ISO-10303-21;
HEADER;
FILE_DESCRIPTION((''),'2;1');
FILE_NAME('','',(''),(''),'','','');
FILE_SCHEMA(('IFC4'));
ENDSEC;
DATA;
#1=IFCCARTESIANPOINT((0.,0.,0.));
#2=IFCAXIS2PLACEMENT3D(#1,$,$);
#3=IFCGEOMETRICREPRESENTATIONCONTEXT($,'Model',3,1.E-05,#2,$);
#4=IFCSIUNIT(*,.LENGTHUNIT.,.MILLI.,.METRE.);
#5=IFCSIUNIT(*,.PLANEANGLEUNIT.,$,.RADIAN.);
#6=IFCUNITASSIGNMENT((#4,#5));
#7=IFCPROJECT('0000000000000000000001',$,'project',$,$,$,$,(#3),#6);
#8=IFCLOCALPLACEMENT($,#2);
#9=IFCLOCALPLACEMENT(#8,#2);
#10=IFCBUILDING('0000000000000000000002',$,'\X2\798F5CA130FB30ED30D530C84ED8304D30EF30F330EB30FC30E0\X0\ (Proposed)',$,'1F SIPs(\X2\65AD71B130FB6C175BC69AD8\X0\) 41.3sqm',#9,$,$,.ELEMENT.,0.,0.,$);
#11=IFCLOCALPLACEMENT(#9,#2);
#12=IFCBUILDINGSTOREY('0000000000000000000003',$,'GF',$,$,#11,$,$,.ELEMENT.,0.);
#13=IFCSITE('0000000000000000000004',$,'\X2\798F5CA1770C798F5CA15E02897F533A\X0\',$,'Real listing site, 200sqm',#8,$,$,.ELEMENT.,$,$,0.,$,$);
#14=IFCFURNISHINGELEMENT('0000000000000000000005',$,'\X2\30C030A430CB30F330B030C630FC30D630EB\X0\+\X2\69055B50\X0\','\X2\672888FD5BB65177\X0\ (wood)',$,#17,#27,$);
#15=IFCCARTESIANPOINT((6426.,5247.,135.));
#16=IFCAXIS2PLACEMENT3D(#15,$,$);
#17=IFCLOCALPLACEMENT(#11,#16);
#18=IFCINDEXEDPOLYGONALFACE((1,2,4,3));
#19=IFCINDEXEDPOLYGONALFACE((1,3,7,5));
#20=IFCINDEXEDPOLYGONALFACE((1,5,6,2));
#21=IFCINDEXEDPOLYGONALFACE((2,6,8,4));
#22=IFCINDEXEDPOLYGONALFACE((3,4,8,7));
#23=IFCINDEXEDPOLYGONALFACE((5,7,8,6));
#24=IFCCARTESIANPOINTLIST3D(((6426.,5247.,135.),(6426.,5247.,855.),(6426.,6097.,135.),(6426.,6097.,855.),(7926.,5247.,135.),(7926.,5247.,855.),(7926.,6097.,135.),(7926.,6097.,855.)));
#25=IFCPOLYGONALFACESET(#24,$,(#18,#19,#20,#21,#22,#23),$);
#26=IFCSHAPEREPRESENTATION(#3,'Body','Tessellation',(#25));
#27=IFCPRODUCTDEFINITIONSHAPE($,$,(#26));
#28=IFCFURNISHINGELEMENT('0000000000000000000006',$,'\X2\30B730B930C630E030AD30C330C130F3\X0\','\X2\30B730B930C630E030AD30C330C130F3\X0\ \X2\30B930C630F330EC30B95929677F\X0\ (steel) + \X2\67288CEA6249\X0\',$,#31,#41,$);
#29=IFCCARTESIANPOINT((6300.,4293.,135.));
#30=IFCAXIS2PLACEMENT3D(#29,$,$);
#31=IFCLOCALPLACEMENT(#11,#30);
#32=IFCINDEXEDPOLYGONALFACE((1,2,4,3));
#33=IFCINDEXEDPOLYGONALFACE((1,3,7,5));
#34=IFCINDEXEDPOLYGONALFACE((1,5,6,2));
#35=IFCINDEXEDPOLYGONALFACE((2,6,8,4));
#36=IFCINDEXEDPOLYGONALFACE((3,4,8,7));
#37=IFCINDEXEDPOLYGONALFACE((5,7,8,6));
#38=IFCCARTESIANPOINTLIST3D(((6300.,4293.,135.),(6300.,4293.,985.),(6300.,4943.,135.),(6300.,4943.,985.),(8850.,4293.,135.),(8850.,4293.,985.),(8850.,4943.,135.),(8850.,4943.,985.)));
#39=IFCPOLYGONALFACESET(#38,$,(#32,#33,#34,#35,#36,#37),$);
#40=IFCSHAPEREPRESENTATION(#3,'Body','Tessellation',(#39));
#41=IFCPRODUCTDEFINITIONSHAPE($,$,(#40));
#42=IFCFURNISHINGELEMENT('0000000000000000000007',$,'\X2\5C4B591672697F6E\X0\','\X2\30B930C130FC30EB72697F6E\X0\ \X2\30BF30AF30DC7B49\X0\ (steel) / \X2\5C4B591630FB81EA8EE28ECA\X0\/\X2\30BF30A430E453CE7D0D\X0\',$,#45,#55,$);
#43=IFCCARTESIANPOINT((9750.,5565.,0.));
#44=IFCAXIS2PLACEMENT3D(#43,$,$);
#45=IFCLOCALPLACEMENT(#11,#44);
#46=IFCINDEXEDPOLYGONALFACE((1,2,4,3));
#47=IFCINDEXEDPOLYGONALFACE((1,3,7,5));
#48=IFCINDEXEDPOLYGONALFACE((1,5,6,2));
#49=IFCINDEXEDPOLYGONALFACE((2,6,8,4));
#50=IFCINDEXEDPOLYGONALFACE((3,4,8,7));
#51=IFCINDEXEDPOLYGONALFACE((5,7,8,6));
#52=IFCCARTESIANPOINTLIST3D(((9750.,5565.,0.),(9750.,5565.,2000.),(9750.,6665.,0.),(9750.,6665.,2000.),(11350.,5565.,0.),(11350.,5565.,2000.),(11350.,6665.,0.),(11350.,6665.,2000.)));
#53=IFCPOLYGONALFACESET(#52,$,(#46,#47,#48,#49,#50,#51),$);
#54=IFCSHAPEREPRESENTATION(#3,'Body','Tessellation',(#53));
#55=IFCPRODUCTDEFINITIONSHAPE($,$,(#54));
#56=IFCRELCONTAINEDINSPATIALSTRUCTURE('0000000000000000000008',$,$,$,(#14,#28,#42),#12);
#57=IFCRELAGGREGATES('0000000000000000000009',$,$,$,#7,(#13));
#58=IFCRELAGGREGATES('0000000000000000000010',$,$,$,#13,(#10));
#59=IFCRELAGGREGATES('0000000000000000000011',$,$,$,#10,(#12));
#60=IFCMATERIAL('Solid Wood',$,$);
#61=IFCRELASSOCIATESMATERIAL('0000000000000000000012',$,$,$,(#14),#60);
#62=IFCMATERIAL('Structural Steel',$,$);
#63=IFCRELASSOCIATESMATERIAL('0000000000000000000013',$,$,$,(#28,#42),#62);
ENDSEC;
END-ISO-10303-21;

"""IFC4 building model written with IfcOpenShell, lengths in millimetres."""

from ifc_helpers import new_model, si_unit, frame, frame_2d, origin, place, context, project, spatial, rectangle, extrude, material, element, save


model = new_model("IFC4")

# Units and contexts
model_context = context("Model", 3, precision=1e-05, world=origin())
ifc_project = project(units=[si_unit("LENGTHUNIT", "METRE", prefix="MILLI"), si_unit("PLANEANGLEUNIT", "RADIAN")], contexts=[model_context])

# Site, building, storey
site_placement = place(None, origin())
site = spatial("IfcSite", under=ifc_project, at=site_placement, Name="福岡県福岡市西区", ObjectType="Real listing site, 200sqm", CompositionType="ELEMENT", RefElevation=0.0)
building_placement = place(site_placement, origin())
building = spatial("IfcBuilding", under=site, at=building_placement, Name="福岡・ロフト付きワンルーム (Proposed)", ObjectType="1F SIPs(断熱・気密高) 41.3sqm", CompositionType="ELEMENT", ElevationOfRefHeight=0.0, ElevationOfTerrain=0.0)
storey_placement = place(building_placement, origin())
storey = spatial("IfcBuildingStorey", under=building, at=storey_placement, Name="GF", CompositionType="ELEMENT", Elevation=0.0)

# Shared definitions
ifc_material_1 = material(Name="Solid Wood")

# Shared definitions
ifc_material_2 = material(Name="Structural Steel")

# Furnishing elements
furnishing_1_placement = place(storey_placement, frame((6426.0, 5247.0, 135.0)))
element("IfcFurnishingElement", 1, at=furnishing_1_placement, inside=storey, material=ifc_material_1, Name="ダイニングテーブル+椅子", Description="木製家具 (wood)", context=model_context, shape_type="SweptSolid", body=[
    extrude(rectangle(XDim=1500.0, YDim=850.0, at=frame_2d((750.0, 425.0))), frame((6426.0, 5247.0, 135.0)), (0.0, 0.0, 1.0), 720.0),
])
furnishing_2_placement = place(storey_placement, frame((6300.0, 4293.0, 135.0)))
element("IfcFurnishingElement", 2, at=furnishing_2_placement, inside=storey, material=ifc_material_2, Name="システムキッチン", Description="システムキッチン ステンレス天板 (steel) + 木質扉", context=model_context, shape_type="SweptSolid", body=[
    extrude(rectangle(XDim=2550.0, YDim=650.0, at=frame_2d((1275.0, 325.0))), frame((6300.0, 4293.0, 135.0)), (0.0, 0.0, 1.0), 850.0),
])
furnishing_3_placement = place(storey_placement, frame((9750.0, 5565.0, 0.0)))
element("IfcFurnishingElement", 3, at=furnishing_3_placement, inside=storey, material=ifc_material_2, Name="屋外物置", Description="スチール物置 タクボ等 (steel) / 屋外・自転車/タイヤ収納", context=model_context, shape_type="SweptSolid", body=[
    extrude(rectangle(XDim=1600.0, YDim=1100.0, at=frame_2d((800.0, 550.0))), frame((9750.0, 5565.0, 0.0)), (0.0, 0.0, 1.0), 2000.0),
])

save(model, "model.ifc")
